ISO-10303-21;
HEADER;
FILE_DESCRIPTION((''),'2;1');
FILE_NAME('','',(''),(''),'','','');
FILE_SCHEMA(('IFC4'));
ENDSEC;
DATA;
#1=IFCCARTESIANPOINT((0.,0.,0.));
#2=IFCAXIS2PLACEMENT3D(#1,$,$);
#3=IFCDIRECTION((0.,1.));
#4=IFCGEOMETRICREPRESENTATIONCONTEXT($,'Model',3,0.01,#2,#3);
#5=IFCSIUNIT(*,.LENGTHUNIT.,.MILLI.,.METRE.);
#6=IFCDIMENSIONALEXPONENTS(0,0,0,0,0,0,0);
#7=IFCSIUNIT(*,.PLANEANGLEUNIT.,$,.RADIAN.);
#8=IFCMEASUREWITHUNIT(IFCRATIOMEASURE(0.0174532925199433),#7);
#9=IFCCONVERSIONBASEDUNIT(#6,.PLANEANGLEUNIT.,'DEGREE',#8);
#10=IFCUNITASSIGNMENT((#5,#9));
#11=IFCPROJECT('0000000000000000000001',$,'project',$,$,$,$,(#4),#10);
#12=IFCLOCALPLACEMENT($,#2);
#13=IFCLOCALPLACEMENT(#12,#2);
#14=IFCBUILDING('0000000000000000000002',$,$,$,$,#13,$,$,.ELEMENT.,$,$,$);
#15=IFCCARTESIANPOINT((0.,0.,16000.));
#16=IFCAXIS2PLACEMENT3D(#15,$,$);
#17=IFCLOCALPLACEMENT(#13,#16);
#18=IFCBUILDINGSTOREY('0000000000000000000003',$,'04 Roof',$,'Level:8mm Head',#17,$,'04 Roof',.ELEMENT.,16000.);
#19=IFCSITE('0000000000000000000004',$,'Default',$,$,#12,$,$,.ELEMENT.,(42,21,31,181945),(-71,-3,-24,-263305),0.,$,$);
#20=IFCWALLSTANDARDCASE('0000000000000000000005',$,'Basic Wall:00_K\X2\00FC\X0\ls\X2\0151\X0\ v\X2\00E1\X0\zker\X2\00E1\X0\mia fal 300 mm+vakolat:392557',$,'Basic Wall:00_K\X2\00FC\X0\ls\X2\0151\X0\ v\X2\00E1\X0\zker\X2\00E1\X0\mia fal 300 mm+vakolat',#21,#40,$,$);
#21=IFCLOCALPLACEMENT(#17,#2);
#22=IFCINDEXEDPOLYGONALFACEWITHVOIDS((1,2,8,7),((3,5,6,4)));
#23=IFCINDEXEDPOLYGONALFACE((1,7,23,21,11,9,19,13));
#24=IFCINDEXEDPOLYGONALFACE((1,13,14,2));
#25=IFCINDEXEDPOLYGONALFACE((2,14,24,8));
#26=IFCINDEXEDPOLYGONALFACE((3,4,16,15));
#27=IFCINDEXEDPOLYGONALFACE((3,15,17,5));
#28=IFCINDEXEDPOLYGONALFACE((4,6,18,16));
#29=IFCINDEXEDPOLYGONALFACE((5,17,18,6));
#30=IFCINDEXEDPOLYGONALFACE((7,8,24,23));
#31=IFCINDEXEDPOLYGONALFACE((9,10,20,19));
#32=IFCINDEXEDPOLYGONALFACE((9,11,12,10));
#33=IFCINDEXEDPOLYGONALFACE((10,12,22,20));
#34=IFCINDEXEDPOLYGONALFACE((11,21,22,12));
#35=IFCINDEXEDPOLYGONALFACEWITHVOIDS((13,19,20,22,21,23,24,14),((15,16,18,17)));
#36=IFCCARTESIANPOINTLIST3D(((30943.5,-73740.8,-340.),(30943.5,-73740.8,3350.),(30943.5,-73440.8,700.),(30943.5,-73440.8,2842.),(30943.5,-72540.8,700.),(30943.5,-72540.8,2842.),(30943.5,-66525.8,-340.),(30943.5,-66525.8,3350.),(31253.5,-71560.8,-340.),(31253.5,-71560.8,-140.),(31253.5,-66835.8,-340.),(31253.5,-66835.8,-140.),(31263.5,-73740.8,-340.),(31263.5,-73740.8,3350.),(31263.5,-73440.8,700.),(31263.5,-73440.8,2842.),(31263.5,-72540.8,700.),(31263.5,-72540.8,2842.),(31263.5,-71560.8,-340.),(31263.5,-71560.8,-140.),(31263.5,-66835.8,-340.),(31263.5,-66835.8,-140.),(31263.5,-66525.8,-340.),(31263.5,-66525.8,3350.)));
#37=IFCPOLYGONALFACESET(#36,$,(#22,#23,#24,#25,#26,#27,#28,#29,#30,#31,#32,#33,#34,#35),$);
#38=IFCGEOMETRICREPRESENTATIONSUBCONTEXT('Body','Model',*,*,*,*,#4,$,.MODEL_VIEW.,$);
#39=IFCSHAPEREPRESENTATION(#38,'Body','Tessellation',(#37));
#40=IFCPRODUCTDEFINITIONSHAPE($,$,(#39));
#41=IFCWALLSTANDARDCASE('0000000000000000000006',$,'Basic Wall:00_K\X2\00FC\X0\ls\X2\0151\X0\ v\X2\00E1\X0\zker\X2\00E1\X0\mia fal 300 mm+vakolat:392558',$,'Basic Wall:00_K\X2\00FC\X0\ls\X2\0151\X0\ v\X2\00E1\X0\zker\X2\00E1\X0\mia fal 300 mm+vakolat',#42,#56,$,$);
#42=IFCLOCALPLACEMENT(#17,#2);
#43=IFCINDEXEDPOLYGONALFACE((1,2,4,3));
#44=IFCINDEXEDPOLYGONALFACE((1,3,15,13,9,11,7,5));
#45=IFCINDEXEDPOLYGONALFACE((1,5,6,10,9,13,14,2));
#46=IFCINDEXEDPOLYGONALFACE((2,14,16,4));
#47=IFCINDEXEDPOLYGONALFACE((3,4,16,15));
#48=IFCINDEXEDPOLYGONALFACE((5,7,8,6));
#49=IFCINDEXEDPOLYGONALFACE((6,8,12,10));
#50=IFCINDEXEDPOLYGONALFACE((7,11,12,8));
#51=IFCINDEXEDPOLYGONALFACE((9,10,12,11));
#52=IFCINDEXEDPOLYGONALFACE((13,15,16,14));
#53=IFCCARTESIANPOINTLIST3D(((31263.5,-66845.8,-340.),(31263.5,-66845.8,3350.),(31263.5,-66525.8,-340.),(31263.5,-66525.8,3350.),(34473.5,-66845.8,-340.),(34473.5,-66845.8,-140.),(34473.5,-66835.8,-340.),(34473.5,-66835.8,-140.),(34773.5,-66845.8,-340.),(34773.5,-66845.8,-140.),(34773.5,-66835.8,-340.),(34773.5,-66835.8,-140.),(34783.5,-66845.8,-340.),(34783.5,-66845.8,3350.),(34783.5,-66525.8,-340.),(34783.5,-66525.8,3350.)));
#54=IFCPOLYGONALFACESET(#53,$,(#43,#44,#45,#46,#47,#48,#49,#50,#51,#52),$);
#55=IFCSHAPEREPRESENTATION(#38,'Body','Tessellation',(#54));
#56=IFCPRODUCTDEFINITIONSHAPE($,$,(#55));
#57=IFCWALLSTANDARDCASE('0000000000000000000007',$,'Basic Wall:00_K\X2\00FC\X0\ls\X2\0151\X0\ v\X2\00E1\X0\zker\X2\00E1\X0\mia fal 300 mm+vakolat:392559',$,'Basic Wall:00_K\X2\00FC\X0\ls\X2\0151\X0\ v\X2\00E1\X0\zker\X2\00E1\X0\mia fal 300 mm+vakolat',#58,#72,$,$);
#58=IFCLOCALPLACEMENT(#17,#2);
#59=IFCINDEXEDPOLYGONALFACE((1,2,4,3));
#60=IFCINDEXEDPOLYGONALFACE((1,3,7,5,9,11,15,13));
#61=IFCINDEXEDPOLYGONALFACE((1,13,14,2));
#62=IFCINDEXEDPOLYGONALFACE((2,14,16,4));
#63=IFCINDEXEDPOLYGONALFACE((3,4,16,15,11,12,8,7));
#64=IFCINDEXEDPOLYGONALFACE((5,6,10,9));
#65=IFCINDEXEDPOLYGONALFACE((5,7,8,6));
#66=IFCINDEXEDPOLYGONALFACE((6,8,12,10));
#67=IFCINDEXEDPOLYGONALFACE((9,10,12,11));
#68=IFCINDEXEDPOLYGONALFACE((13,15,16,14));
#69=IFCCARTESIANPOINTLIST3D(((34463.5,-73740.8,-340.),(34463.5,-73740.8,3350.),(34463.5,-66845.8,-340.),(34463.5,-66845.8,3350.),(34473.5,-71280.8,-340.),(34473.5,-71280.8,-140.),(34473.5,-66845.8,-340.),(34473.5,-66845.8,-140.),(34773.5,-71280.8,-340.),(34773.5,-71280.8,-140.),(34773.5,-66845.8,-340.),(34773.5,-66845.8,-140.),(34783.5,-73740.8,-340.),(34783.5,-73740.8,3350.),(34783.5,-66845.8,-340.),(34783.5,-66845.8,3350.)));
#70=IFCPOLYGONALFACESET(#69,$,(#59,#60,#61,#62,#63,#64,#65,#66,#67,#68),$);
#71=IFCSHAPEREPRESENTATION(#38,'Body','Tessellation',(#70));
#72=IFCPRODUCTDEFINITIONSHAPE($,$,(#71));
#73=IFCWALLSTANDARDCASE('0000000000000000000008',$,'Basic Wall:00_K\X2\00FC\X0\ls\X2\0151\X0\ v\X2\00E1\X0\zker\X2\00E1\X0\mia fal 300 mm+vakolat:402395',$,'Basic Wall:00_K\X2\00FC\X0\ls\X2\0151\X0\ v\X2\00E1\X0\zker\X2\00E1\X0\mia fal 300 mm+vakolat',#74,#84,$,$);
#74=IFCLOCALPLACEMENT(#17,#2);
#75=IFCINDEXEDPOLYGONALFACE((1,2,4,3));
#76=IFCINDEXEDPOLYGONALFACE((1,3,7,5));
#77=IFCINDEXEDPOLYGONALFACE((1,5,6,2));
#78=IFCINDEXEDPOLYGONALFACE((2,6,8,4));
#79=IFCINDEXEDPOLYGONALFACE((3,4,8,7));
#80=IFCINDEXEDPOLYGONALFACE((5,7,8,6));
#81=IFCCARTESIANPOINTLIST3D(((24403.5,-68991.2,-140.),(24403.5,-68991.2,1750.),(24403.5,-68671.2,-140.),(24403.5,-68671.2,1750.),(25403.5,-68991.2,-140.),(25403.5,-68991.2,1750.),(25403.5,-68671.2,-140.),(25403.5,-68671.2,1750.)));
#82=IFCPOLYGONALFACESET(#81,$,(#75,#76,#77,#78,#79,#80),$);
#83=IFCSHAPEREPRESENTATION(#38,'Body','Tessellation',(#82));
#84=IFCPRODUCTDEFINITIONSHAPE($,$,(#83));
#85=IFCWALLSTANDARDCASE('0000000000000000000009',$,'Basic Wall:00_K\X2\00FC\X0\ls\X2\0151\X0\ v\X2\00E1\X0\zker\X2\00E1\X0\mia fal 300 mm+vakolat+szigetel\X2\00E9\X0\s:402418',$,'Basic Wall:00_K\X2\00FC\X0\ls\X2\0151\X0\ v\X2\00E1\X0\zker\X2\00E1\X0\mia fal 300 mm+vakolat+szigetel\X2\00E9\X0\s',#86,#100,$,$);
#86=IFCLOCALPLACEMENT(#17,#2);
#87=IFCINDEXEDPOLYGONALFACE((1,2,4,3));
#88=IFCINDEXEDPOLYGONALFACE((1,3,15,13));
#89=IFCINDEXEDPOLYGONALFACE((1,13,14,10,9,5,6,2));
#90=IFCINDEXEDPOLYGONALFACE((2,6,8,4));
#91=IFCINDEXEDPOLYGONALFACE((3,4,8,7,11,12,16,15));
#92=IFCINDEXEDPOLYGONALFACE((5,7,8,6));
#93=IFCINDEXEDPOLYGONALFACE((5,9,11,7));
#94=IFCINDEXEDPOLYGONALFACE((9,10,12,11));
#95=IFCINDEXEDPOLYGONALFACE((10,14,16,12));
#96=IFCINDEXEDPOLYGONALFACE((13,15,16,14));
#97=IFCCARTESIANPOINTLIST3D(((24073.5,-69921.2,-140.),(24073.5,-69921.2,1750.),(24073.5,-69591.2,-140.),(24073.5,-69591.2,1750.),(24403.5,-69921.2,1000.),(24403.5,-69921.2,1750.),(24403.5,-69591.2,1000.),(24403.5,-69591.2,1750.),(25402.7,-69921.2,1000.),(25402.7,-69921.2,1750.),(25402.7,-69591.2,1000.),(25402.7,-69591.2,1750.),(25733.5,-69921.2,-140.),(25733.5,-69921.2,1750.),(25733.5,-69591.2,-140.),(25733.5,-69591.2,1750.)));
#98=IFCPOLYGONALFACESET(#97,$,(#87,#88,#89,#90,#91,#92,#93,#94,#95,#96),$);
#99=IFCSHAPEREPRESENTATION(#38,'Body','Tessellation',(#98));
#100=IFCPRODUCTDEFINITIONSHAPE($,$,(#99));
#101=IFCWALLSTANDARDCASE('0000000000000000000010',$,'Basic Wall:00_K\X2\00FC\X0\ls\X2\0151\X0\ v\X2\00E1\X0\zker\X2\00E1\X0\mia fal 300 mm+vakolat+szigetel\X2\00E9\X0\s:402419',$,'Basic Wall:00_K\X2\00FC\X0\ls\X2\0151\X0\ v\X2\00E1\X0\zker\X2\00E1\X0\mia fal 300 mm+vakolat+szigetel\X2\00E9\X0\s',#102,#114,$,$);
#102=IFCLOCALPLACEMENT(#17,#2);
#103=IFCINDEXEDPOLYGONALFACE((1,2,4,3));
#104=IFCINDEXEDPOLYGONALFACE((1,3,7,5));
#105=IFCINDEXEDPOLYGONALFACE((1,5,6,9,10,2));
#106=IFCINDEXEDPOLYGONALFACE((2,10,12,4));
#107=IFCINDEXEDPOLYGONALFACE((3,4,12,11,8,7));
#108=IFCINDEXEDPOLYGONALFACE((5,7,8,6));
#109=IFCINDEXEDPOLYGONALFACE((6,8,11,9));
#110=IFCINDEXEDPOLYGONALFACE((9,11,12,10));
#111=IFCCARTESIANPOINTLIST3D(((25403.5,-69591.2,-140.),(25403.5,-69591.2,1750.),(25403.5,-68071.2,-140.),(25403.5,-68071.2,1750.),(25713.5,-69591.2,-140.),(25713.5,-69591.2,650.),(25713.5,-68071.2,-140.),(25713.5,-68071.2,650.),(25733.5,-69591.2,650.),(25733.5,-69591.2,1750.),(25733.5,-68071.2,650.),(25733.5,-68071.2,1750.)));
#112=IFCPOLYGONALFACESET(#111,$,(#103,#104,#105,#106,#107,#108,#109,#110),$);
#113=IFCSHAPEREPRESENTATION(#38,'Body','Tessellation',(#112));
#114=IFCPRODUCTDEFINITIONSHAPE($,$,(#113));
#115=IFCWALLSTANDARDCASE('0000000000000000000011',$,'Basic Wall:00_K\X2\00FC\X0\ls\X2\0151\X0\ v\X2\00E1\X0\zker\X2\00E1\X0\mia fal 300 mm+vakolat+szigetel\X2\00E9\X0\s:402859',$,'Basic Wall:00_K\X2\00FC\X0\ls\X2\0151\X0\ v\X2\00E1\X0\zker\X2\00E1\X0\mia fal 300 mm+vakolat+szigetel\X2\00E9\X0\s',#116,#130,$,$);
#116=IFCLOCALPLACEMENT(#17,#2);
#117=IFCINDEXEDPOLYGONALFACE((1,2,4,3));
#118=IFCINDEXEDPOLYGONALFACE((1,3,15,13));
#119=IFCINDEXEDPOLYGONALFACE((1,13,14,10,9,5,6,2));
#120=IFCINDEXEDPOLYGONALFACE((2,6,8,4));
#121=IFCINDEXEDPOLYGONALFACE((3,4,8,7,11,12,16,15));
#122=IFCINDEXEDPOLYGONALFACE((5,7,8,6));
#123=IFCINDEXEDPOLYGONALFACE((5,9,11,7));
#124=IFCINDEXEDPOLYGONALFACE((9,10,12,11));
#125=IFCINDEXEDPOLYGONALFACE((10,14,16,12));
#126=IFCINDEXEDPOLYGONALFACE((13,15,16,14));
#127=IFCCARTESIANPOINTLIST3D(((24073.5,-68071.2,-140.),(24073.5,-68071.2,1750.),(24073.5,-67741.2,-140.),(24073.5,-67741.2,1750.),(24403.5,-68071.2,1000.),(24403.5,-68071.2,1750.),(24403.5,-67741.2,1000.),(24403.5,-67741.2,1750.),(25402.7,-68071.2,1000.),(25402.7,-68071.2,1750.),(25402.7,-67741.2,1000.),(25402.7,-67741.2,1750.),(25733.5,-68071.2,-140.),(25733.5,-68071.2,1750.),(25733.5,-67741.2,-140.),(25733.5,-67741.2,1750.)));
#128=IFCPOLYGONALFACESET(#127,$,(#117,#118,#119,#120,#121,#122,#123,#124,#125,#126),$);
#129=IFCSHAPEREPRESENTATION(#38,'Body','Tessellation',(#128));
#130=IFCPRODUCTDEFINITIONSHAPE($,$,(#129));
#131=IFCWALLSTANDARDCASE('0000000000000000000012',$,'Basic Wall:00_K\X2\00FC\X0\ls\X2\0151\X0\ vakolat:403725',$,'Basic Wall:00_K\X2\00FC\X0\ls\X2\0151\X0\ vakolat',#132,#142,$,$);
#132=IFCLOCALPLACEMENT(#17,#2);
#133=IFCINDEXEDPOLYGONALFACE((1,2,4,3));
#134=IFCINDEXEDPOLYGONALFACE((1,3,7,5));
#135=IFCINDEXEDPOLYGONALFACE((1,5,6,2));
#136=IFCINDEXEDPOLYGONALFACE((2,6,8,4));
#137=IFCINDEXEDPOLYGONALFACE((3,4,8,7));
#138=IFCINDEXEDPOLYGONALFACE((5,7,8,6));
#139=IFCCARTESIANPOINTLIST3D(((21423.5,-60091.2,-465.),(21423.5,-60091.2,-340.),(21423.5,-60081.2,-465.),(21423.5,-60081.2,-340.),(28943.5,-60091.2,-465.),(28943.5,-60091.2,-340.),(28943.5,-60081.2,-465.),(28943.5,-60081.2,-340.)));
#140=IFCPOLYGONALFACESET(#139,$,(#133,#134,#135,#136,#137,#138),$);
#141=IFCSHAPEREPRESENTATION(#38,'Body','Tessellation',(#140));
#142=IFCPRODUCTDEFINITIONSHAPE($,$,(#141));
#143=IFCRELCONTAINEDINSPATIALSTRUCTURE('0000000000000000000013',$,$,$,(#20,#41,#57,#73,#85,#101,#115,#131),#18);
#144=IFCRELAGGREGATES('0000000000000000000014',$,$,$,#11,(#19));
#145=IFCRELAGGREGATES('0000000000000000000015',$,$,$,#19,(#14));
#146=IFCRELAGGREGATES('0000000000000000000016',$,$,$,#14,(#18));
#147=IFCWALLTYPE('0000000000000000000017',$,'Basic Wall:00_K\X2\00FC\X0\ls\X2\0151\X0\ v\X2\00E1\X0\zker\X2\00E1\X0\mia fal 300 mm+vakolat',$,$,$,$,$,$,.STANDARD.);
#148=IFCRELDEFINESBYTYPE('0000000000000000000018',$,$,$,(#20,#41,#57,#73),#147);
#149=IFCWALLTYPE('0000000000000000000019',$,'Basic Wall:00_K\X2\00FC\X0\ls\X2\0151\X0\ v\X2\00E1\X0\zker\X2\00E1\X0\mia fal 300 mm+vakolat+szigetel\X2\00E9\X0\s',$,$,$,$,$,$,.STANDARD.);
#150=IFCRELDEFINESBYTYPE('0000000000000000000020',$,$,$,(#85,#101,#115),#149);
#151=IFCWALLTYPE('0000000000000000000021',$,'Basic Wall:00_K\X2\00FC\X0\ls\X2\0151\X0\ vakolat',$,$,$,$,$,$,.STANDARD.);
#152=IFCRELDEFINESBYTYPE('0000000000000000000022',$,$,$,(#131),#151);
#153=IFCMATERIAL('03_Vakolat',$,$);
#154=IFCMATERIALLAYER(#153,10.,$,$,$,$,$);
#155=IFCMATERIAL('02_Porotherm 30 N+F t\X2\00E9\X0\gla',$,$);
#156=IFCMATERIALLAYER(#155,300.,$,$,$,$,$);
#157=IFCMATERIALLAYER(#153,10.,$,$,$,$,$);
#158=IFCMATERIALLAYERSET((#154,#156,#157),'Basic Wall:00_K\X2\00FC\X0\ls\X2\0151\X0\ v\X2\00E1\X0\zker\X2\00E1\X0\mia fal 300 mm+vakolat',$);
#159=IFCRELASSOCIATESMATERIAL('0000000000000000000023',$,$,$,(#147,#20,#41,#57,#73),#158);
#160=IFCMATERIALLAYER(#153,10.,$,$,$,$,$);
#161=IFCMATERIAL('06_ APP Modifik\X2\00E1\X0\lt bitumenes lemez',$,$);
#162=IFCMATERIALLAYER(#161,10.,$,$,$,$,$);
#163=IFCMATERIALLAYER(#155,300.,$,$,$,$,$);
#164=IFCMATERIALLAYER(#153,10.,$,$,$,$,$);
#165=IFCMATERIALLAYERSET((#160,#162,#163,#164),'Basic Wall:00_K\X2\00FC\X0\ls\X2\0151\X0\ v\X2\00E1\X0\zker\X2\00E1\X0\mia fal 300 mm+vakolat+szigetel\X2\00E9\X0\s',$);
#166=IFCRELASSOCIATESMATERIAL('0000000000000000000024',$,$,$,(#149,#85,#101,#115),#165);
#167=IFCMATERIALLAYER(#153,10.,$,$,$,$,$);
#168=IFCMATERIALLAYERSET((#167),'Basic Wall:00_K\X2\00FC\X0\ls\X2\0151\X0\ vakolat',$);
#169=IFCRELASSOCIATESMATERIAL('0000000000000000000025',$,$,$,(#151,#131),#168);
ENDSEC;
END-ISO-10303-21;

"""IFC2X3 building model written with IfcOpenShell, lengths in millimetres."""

from ifc_helpers import new_model, entity, si_unit, converted_unit, direction, frame, frame_2d, origin, origin_2d_with_axis, place, context, subcontext, project, spatial, polyline, rectangle, extrude, clip, bounded_halfspace, material, layer, layer_set, layer_usage, type_object, element, save


model = new_model("IFC2X3")

# Units and contexts
model_context = context("Model", 3, precision=0.01, world=origin(), true_north=direction((0.0, 1.0)))
body_context = subcontext(model_context, "Body", "Model", "MODEL_VIEW")
ifc_project = project(units=[si_unit("LENGTHUNIT", "METRE", prefix="MILLI"), converted_unit("PLANEANGLEUNIT", "DEGREE", entity("IfcRatioMeasure", 0.0174532925199433), si_unit("PLANEANGLEUNIT", "RADIAN"), dimensions=[0, 0, 0, 0, 0, 0, 0])], contexts=[model_context])

# Site, building, storey
site_placement = place(None, origin())
site = spatial("IfcSite", under=ifc_project, at=site_placement, Name="Default", CompositionType="ELEMENT", RefLatitude=(42, 21, 31, 181945), RefLongitude=(-71, -3, -24, -263305), RefElevation=0.0)
building_placement = place(site_placement, origin())
building = spatial("IfcBuilding", under=site, at=building_placement, CompositionType="ELEMENT")
storey_placement = place(building_placement, frame((0.0, 0.0, 16000.0)))
storey = spatial("IfcBuildingStorey", under=building, at=storey_placement, Name="04 Roof", ObjectType="Level:8mm Head", LongName="04 Roof", CompositionType="ELEMENT", Elevation=16000.0)

# Wall, openings
ifc_material_1 = material(Name="03_Vakolat")
ifc_layer_1 = layer(ifc_material_1, 10.0)
ifc_material_2 = material(Name="02_Porotherm 30 N+F tégla")
ifc_layer_2 = layer(ifc_material_2, 300.0)
ifc_layer_3 = layer(ifc_material_1, 10.0)
ifc_layer_set_1 = layer_set([ifc_layer_1, ifc_layer_2, ifc_layer_3], Name="Basic Wall:00_Külső vázkerámia fal 300 mm+vakolat")
ifc_layer_usage_1 = layer_usage(ifc_layer_set_1, "AXIS2", "NEGATIVE", 160.0)
wall_type_1 = type_object("IfcWallType", Name="Basic Wall:00_Külső vázkerámia fal 300 mm+vakolat", PredefinedType="STANDARD", material=ifc_layer_set_1)
wall_1_placement = place(storey_placement, frame((31103.5, -66525.8, -340.0), z_axis=(0.0, 0.0, 1.0), x_axis=(0.0, -1.0, 0.0)))
wall_1 = element("IfcWallStandardCase", 1, at=wall_1_placement, inside=storey, type_object=wall_type_1, material=ifc_layer_usage_1, Name="Basic Wall:00_Külső vázkerámia fal 300 mm+vakolat:392557", ObjectType="Basic Wall:00_Külső vázkerámia fal 300 mm+vakolat", context=body_context, shape_type="SweptSolid", body=[
    extrude(rectangle(XDim=7215.0, YDim=320.0, at=frame_2d((3607.5, 0.0), x_axis=(-1.0, 0.0))), origin(), (0.0, 0.0, 1.0), 3690.0),
])
opening_1_placement = place(storey_placement, frame((31103.5, -66525.8, -340.0), z_axis=(0.0, 0.0, 1.0), x_axis=(0.0, -1.0, 0.0)))
element("IfcOpeningElement", 2, at=opening_1_placement, cuts=wall_1, ObjectType="Opening", context=body_context, shape_type="SweptSolid", body=[
    extrude(rectangle(XDim=200.0, YDim=10.0, at=frame_2d((0.0, 0.0), x_axis=(0.0, 1.0))), frame((5035.0, 155.0, 100.0), z_axis=(-1.0, 0.0, 0.0), x_axis=(0.0, 1.0, 0.0)), (0.0, 0.0, 1.0), 4725.0),
])
opening_2_placement = place(wall_1_placement, frame((6915.0, -1684.0, 1040.0), z_axis=(0.0, 0.0, 1.0), x_axis=(0.0, 1.0, 0.0)))
element("IfcOpeningElement", 3, at=opening_2_placement, cuts=wall_1, ObjectType="Opening", context=body_context, shape_type="SweptSolid", body=[
    extrude(rectangle(XDim=2142.0, YDim=900.0, at=origin_2d_with_axis()), frame((0.0, 450.0, 1071.0), z_axis=(1.0, 0.0, 0.0), x_axis=(0.0, 0.0, 1.0)), (0.0, 0.0, 1.0), 3048.0),
])

# Walls, openings
ifc_layer_usage_2 = layer_usage(ifc_layer_set_1, "AXIS2", "NEGATIVE", 160.0)
wall_2_placement = place(storey_placement, frame((31263.5, -66685.8, -340.0)))
wall_2 = element("IfcWallStandardCase", 4, at=wall_2_placement, inside=storey, type_object=wall_type_1, material=ifc_layer_usage_2, Name="Basic Wall:00_Külső vázkerámia fal 300 mm+vakolat:392558", ObjectType="Basic Wall:00_Külső vázkerámia fal 300 mm+vakolat", context=body_context, shape_type="SweptSolid", body=[
    extrude(rectangle(XDim=3520.0, YDim=320.0, at=frame_2d((1760.0, 0.0), x_axis=(-1.0, 0.0))), origin(), (0.0, 0.0, 1.0), 3690.0),
])
opening_3_placement = place(storey_placement, frame((31263.5, -66685.8, -340.0)))
element("IfcOpeningElement", 5, at=opening_3_placement, cuts=wall_2, ObjectType="Opening", context=body_context, shape_type="SweptSolid", body=[
    extrude(rectangle(XDim=200.0, YDim=10.0, at=frame_2d((0.0, 0.0), x_axis=(1.0, 0.0))), frame((3210.0, -155.0, 100.0), z_axis=(1.0, 0.0, 0.0), x_axis=(0.0, 0.0, 1.0)), (0.0, 0.0, 1.0), 300.0),
])
ifc_layer_usage_3 = layer_usage(ifc_layer_set_1, "AXIS2", "NEGATIVE", 160.0)
wall_3_placement = place(storey_placement, frame((34623.5, -66845.8, -340.0), z_axis=(0.0, 0.0, 1.0), x_axis=(0.0, -1.0, 0.0)))
wall_3 = element("IfcWallStandardCase", 6, at=wall_3_placement, inside=storey, type_object=wall_type_1, material=ifc_layer_usage_3, Name="Basic Wall:00_Külső vázkerámia fal 300 mm+vakolat:392559", ObjectType="Basic Wall:00_Külső vázkerámia fal 300 mm+vakolat", context=body_context, shape_type="SweptSolid", body=[
    extrude(rectangle(XDim=6895.0, YDim=320.0, at=frame_2d((3447.5, 0.0), x_axis=(-1.0, 0.0))), origin(), (0.0, 0.0, 1.0), 3690.0),
])
opening_4_placement = place(storey_placement, frame((34623.5, -66845.8, -340.0), z_axis=(0.0, 0.0, 1.0), x_axis=(0.0, -1.0, 0.0)))
element("IfcOpeningElement", 7, at=opening_4_placement, cuts=wall_3, ObjectType="Opening", context=body_context, shape_type="SweptSolid", body=[
    extrude(rectangle(XDim=200.0, YDim=4435.0, at=frame_2d((0.0, 0.0), x_axis=(1.0, 0.0))), frame((2217.5, -150.0, 100.0), z_axis=(0.0, 1.0, 0.0), x_axis=(0.0, 0.0, -1.0)), (0.0, 0.0, 1.0), 300.0),
])

# Wall
ifc_layer_usage_4 = layer_usage(ifc_layer_set_1, "AXIS2", "NEGATIVE", 160.0)
wall_4_placement = place(storey_placement, frame((24403.5, -68831.2, -140.0)))
element("IfcWallStandardCase", 8, at=wall_4_placement, inside=storey, type_object=wall_type_1, material=ifc_layer_usage_4, Name="Basic Wall:00_Külső vázkerámia fal 300 mm+vakolat:402395", ObjectType="Basic Wall:00_Külső vázkerámia fal 300 mm+vakolat", context=body_context, shape_type="SweptSolid", body=[
    extrude(rectangle(XDim=1000.0, YDim=320.0, at=frame_2d((500.0, 0.0), x_axis=(-1.0, 0.0))), origin(), (0.0, 0.0, 1.0), 1890.0),
])

# Wall, opening
ifc_layer_4 = layer(ifc_material_1, 10.0)
ifc_material_3 = material(Name="06_ APP Modifikált bitumenes lemez")
ifc_layer_5 = layer(ifc_material_3, 10.0)
ifc_layer_6 = layer(ifc_material_2, 300.0)
ifc_layer_7 = layer(ifc_material_1, 10.0)
ifc_layer_set_2 = layer_set([ifc_layer_4, ifc_layer_5, ifc_layer_6, ifc_layer_7], Name="Basic Wall:00_Külső vázkerámia fal 300 mm+vakolat+szigetelés")
ifc_layer_usage_5 = layer_usage(ifc_layer_set_2, "AXIS2", "NEGATIVE", 165.0)
wall_type_2 = type_object("IfcWallType", Name="Basic Wall:00_Külső vázkerámia fal 300 mm+vakolat+szigetelés", PredefinedType="STANDARD", material=ifc_layer_set_2)
wall_5_placement = place(storey_placement, frame((25733.5, -69756.2, -140.0), z_axis=(0.0, 0.0, 1.0), x_axis=(-1.0, 0.0, 0.0)))
wall_5 = element("IfcWallStandardCase", 9, at=wall_5_placement, inside=storey, type_object=wall_type_2, material=ifc_layer_usage_5, Name="Basic Wall:00_Külső vázkerámia fal 300 mm+vakolat+szigetelés:402418", ObjectType="Basic Wall:00_Külső vázkerámia fal 300 mm+vakolat+szigetelés", context=body_context, shape_type="SweptSolid", body=[
    extrude(rectangle(XDim=1660.0, YDim=330.0, at=frame_2d((830.0, 0.0), x_axis=(-1.0, 0.0))), origin(), (0.0, 0.0, 1.0), 1890.0),
])
opening_5_placement = place(wall_5_placement, frame((1330.0, 165.0, 1140.0)))
element("IfcOpeningElement", 10, at=opening_5_placement, cuts=wall_5, ObjectType="Opening", context=body_context, shape_type="SweptSolid", body=[
    extrude(rectangle(XDim=750.0, YDim=999.2, at=frame_2d((0.0, 0.0), x_axis=(1.0, 0.0))), frame((-499.6, -330.0, 375.0), z_axis=(0.0, 1.0, 0.0), x_axis=(0.0, 0.0, -1.0)), (0.0, 0.0, 1.0), 330.0),
])

# Wall
ifc_layer_usage_6 = layer_usage(ifc_layer_set_2, "AXIS2", "NEGATIVE", 165.0)
wall_6_placement = place(storey_placement, frame((25568.5, -68071.2, -140.0), z_axis=(0.0, 0.0, 1.0), x_axis=(0.0, -1.0, 0.0)))
element("IfcWallStandardCase", 11, at=wall_6_placement, inside=storey, type_object=wall_type_2, material=ifc_layer_usage_6, Name="Basic Wall:00_Külső vázkerámia fal 300 mm+vakolat+szigetelés:402419", ObjectType="Basic Wall:00_Külső vázkerámia fal 300 mm+vakolat+szigetelés", context=body_context, shape_type="Clipping", body=[
    clip(clip(extrude(rectangle(XDim=1520.0, YDim=330.0, at=frame_2d((760.0, 0.0), x_axis=(-1.0, 0.0))), origin(), (0.0, 0.0, 1.0), 1890.0), bounded_halfspace(frame((1520.0, 145.0, 790.0), z_axis=(0.0, 0.0, 1.0), x_axis=(0.0, -1.0, 0.0)), True, frame((1520.0, 145.0, 790.0), z_axis=(0.0, 0.0, 1.0), x_axis=(0.0, -1.0, 0.0)), polyline([(0.0, 0.0), (-20.0, 0.0), (-20.0, -1520.0), (0.0, -1520.0), (0.0, 0.0)]))), bounded_halfspace(frame((0.0, 145.0, 790.0), z_axis=(0.0, -1.0, 0.0), x_axis=(0.0, 0.0, 1.0)), True, frame((0.0, 145.0, 790.0), z_axis=(0.0, -1.0, 0.0), x_axis=(0.0, 0.0, 1.0)), polyline([(0.0, 0.0), (-790.0, 0.0), (-790.0, -1520.0), (0.0, -1520.0), (0.0, 0.0)]))),
])

# Wall, opening
ifc_layer_usage_7 = layer_usage(ifc_layer_set_2, "AXIS2", "POSITIVE", -165.0)
wall_7_placement = place(storey_placement, frame((25733.5, -67906.2, -140.0), z_axis=(0.0, 0.0, 1.0), x_axis=(-1.0, 0.0, 0.0)))
wall_7 = element("IfcWallStandardCase", 12, at=wall_7_placement, inside=storey, type_object=wall_type_2, material=ifc_layer_usage_7, Name="Basic Wall:00_Külső vázkerámia fal 300 mm+vakolat+szigetelés:402859", ObjectType="Basic Wall:00_Külső vázkerámia fal 300 mm+vakolat+szigetelés", context=body_context, shape_type="SweptSolid", body=[
    extrude(rectangle(XDim=1660.0, YDim=330.0, at=frame_2d((830.0, 0.0), x_axis=(-1.0, 0.0))), origin(), (0.0, 0.0, 1.0), 1890.0),
])
opening_6_placement = place(wall_7_placement, frame((1330.0, 165.0, 1140.0)))
element("IfcOpeningElement", 13, at=opening_6_placement, cuts=wall_7, ObjectType="Opening", context=body_context, shape_type="SweptSolid", body=[
    extrude(rectangle(XDim=750.0, YDim=999.2, at=frame_2d((0.0, 0.0), x_axis=(1.0, 0.0))), frame((-499.6, -330.0, 375.0), z_axis=(0.0, 1.0, 0.0), x_axis=(0.0, 0.0, -1.0)), (0.0, 0.0, 1.0), 330.0),
])

# Wall
ifc_layer_8 = layer(ifc_material_1, 10.0)
ifc_layer_set_3 = layer_set([ifc_layer_8], Name="Basic Wall:00_Külső vakolat")
ifc_layer_usage_8 = layer_usage(ifc_layer_set_3, "AXIS2", "NEGATIVE", 5.0)
wall_type_3 = type_object("IfcWallType", Name="Basic Wall:00_Külső vakolat", PredefinedType="STANDARD", material=ifc_layer_set_3)
wall_8_placement = place(storey_placement, frame((28943.5, -60086.2, -465.0), z_axis=(0.0, 0.0, 1.0), x_axis=(-1.0, 0.0, 0.0)))
element("IfcWallStandardCase", 14, at=wall_8_placement, inside=storey, type_object=wall_type_3, material=ifc_layer_usage_8, Name="Basic Wall:00_Külső vakolat:403725", ObjectType="Basic Wall:00_Külső vakolat", context=body_context, shape_type="SweptSolid", body=[
    extrude(rectangle(XDim=7520.0, YDim=10.0, at=frame_2d((3760.0, 0.0), x_axis=(-1.0, 0.0))), origin(), (0.0, 0.0, 1.0), 125.0),
])

save(model, "model.ifc")
